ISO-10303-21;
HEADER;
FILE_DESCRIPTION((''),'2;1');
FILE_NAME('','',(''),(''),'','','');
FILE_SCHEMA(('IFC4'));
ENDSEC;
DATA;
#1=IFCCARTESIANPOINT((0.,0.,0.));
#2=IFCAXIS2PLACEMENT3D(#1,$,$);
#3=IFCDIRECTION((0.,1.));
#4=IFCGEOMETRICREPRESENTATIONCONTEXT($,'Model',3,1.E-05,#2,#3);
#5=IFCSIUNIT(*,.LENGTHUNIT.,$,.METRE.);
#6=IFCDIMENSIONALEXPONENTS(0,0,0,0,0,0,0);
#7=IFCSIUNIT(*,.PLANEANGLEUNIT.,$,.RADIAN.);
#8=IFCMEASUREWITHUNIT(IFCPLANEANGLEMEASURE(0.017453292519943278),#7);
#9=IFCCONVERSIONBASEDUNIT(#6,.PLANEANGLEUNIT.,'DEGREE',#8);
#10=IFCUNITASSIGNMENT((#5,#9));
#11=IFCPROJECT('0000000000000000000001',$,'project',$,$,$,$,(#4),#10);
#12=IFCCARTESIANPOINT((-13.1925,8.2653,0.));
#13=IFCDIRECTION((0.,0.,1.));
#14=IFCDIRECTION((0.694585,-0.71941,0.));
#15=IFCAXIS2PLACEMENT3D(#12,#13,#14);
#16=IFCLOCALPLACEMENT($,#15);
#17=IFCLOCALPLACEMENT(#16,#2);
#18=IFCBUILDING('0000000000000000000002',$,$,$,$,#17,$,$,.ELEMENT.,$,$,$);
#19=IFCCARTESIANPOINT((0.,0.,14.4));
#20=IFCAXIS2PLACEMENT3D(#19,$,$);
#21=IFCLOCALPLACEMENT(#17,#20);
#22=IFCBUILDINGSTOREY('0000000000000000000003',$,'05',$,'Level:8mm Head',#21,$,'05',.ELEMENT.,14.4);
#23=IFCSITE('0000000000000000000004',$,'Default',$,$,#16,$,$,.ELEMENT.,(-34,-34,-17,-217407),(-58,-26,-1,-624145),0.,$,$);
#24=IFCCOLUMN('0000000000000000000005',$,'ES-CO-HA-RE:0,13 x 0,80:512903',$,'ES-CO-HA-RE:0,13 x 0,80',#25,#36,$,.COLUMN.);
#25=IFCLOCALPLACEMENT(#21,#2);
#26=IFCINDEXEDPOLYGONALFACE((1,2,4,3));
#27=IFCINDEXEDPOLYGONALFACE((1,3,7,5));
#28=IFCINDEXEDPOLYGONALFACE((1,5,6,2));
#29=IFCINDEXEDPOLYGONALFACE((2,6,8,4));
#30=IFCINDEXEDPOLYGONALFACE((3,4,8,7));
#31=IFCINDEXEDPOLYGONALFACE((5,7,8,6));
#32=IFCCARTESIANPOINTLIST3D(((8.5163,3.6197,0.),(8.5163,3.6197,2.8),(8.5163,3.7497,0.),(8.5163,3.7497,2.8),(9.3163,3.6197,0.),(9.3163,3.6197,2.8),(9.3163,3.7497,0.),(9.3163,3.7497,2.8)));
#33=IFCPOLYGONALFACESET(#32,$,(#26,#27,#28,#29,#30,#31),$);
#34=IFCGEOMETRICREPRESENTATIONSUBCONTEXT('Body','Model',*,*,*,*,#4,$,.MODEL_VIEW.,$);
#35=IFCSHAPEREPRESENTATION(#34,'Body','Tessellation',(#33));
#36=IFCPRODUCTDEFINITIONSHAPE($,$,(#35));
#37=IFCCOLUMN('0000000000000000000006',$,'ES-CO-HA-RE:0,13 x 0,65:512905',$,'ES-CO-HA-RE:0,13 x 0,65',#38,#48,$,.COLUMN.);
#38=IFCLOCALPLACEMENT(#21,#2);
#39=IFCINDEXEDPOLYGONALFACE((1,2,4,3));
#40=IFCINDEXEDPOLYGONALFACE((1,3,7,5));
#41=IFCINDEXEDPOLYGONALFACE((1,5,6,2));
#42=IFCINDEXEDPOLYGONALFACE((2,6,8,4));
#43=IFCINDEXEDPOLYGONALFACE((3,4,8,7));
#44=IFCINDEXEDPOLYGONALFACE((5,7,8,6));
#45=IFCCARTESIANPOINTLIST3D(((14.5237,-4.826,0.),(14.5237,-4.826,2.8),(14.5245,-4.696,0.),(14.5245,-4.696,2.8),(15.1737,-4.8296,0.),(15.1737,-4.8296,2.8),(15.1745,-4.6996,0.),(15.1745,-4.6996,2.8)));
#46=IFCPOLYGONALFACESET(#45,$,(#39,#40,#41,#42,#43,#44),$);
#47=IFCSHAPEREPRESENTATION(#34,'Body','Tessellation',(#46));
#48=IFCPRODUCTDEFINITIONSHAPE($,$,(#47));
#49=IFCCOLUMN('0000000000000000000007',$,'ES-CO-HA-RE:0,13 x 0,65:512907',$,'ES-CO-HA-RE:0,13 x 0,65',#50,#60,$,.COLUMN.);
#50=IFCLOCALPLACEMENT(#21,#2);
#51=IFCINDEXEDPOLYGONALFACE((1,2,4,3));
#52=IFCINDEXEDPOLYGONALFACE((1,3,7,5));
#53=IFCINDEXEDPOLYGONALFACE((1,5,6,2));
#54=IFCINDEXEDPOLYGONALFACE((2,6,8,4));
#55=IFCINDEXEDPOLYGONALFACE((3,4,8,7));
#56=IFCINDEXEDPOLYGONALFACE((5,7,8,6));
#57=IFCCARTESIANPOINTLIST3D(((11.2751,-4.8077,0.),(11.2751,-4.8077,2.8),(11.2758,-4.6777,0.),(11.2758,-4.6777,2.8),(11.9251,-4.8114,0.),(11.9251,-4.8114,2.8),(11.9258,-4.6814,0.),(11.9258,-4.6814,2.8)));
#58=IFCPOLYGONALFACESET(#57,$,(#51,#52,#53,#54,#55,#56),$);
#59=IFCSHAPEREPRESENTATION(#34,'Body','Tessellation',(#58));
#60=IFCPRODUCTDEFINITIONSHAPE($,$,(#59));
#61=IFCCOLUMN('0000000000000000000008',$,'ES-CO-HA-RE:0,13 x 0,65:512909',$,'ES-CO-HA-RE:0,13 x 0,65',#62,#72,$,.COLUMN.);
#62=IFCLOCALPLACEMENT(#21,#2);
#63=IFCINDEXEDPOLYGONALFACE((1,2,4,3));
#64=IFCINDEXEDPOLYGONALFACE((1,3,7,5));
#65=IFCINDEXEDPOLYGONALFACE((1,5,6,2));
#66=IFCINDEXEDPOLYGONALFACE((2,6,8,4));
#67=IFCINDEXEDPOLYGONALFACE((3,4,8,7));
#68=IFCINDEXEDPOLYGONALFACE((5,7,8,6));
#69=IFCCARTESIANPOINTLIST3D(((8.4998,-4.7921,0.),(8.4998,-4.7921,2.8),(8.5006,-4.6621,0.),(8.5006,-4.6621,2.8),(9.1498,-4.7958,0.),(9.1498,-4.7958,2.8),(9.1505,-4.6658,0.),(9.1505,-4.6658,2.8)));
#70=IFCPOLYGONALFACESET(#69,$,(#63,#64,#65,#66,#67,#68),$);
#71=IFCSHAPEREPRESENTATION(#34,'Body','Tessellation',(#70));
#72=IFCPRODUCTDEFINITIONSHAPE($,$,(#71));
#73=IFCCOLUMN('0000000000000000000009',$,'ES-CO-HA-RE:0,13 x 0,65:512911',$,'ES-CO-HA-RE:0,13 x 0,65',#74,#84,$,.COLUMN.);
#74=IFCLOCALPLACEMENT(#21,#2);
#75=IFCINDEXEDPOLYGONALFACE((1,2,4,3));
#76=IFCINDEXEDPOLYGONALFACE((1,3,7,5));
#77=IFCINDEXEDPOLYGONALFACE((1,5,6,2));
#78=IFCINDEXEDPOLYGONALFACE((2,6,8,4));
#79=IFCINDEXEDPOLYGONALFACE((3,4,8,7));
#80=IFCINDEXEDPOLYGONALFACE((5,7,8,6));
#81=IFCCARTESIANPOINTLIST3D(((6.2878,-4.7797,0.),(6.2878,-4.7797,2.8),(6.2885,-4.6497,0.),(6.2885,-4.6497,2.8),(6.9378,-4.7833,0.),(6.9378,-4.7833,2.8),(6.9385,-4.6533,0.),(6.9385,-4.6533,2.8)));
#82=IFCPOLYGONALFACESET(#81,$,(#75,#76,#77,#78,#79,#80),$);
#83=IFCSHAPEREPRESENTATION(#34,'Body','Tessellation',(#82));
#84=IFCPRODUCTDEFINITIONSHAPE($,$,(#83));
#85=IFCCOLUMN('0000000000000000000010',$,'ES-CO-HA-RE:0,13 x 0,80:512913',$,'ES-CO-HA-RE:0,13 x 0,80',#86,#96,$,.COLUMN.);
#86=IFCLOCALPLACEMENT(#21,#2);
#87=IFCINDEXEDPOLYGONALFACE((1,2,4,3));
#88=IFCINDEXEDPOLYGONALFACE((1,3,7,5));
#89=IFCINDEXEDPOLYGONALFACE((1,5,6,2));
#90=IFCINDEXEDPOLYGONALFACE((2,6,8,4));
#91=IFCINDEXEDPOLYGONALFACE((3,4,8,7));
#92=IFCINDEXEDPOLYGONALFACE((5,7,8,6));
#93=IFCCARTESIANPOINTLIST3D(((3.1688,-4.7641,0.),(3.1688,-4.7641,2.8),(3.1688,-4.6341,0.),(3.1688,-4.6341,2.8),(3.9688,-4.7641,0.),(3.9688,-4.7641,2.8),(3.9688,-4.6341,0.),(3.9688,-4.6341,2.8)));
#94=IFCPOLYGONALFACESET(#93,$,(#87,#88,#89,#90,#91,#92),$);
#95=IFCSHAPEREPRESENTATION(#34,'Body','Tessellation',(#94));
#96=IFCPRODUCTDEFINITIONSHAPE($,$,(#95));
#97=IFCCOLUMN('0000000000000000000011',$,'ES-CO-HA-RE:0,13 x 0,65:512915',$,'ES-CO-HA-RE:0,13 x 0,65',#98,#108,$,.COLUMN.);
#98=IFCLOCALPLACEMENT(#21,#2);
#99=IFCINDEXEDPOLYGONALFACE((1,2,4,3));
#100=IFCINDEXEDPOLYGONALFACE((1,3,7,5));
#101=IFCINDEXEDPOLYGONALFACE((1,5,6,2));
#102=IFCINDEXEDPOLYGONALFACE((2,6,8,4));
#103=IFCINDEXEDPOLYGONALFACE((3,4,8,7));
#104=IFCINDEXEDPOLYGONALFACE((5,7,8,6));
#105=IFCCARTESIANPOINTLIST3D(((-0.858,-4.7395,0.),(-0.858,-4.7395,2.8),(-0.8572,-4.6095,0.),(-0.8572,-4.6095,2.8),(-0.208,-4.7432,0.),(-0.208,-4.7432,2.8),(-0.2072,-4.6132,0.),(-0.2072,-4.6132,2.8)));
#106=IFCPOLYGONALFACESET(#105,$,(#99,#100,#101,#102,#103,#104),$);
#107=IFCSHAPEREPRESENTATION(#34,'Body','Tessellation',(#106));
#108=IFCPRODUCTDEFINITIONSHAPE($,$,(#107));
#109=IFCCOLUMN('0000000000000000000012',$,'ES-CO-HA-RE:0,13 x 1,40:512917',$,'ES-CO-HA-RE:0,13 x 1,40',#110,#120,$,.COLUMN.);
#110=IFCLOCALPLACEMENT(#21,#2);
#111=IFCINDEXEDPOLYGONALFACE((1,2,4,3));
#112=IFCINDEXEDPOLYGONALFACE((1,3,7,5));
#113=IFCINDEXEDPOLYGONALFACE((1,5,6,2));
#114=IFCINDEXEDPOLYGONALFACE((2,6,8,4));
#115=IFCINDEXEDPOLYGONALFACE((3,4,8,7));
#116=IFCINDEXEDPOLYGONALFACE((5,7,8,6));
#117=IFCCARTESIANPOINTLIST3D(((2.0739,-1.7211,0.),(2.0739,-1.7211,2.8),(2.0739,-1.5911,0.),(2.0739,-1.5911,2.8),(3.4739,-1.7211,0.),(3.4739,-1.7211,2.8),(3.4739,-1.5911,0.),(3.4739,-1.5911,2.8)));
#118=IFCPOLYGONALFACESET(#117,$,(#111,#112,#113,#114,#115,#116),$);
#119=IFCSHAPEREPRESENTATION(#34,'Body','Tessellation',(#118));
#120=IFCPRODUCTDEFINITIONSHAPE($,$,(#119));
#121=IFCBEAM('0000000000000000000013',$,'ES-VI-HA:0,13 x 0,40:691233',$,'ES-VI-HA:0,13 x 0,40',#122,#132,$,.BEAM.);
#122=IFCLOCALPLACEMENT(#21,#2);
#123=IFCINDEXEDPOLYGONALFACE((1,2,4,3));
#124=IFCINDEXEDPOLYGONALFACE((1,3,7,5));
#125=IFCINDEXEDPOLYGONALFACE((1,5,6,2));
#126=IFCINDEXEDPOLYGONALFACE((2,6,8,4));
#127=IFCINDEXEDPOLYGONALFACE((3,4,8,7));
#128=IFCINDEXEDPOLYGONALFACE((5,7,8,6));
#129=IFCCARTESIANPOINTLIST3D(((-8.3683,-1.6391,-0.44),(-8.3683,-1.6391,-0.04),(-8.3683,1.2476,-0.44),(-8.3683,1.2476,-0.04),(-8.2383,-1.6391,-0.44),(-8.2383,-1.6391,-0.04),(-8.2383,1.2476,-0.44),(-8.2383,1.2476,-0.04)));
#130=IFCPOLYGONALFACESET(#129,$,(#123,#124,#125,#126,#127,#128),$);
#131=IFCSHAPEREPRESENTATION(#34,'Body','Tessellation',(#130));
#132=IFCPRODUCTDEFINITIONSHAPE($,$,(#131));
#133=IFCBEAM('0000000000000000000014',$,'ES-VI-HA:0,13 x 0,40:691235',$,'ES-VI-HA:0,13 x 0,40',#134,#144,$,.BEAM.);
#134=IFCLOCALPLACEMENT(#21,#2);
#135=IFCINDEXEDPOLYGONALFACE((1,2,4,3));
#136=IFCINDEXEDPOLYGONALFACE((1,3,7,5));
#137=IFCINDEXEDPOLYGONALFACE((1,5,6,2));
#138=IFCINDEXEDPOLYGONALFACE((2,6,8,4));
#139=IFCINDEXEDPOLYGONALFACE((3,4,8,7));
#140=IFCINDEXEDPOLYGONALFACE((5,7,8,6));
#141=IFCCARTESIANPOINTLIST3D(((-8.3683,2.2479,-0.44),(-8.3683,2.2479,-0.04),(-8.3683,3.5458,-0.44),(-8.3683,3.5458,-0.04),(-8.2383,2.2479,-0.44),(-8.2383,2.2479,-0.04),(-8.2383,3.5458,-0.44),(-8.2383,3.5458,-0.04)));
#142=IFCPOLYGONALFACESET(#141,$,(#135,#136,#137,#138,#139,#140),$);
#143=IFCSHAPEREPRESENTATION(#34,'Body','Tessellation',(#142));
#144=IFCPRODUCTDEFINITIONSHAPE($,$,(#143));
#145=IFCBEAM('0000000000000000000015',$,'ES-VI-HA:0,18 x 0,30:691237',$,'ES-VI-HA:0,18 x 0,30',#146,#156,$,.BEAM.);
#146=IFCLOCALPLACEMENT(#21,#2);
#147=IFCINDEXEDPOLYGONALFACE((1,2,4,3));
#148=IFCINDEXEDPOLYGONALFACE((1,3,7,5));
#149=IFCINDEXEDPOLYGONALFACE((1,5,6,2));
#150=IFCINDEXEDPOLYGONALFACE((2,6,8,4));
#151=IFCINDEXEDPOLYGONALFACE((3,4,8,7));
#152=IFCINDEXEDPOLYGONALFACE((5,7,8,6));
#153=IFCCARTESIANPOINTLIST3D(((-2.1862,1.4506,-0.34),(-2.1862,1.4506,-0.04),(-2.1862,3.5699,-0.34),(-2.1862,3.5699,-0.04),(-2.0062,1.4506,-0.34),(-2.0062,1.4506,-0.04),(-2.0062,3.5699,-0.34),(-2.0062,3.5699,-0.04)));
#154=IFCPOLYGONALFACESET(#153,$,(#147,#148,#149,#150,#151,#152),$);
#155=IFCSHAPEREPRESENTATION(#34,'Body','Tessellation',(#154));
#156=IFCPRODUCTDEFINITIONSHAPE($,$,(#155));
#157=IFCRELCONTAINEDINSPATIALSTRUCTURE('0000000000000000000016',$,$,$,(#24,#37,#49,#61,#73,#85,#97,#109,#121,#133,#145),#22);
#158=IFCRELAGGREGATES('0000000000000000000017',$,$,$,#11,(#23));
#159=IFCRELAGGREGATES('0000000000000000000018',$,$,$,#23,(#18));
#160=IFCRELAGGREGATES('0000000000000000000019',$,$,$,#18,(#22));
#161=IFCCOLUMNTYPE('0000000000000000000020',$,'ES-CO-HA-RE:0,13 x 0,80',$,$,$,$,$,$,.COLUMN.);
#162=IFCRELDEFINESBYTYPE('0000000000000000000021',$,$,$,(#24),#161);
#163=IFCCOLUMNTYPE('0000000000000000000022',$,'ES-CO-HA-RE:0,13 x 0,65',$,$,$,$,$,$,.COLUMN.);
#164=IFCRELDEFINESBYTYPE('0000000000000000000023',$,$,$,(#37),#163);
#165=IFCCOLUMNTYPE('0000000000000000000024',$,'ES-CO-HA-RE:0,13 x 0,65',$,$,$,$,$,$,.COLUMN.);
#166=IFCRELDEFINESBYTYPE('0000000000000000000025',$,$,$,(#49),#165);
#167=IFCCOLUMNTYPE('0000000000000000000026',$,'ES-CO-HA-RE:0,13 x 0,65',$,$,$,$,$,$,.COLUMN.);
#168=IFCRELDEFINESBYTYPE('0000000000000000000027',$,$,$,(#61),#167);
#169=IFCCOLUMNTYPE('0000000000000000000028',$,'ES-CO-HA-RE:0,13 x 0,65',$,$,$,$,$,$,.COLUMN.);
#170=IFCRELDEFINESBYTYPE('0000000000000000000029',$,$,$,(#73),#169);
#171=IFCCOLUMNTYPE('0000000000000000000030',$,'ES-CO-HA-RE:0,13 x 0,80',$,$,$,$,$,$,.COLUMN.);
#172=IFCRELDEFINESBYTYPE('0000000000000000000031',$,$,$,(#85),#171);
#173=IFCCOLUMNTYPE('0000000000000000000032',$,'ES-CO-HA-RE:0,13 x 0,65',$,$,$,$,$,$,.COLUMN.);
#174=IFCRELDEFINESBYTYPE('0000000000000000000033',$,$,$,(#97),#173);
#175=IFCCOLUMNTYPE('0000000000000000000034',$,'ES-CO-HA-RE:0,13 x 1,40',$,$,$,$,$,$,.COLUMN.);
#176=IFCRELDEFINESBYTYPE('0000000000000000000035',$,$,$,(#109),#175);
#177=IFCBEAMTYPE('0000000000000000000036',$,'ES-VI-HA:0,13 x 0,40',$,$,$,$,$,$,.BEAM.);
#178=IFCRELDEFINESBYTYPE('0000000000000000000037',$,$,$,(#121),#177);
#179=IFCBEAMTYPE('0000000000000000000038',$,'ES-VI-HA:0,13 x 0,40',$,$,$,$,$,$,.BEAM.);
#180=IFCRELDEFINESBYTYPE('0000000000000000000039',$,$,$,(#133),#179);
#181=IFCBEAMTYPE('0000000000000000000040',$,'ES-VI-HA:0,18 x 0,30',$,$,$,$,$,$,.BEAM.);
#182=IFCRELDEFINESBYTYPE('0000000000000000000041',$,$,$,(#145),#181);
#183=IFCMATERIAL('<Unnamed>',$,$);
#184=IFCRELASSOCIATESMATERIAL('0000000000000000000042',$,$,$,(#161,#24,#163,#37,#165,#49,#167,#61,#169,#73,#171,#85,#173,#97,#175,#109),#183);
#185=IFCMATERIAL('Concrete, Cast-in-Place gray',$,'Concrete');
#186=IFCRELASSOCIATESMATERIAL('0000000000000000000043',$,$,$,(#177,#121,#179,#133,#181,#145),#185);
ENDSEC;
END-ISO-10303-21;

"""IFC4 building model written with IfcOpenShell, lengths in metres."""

from ifc_helpers import new_model, entity, si_unit, converted_unit, direction, frame, origin, place, context, subcontext, project, spatial, indexed_curve, outline, extrude, source, transform, mapped, material, type_object, type_shapes, element, save


model = new_model("IFC4")

# Units and contexts
model_context = context("Model", 3, precision=1e-05, world=origin(), true_north=direction((0.0, 1.0)))
body_context = subcontext(model_context, "Body", "Model", "MODEL_VIEW")
ifc_project = project(units=[si_unit("LENGTHUNIT", "METRE"), converted_unit("PLANEANGLEUNIT", "DEGREE", entity("IfcPlaneAngleMeasure", 0.017453292519943278), si_unit("PLANEANGLEUNIT", "RADIAN"), dimensions=[0, 0, 0, 0, 0, 0, 0])], contexts=[model_context])

# Site, building, storey
site_placement = place(None, frame((-13.1925, 8.2653, 0.0), z_axis=(0.0, 0.0, 1.0), x_axis=(0.694585, -0.71941, 0.0)))
site = spatial("IfcSite", under=ifc_project, at=site_placement, Name="Default", CompositionType="ELEMENT", RefLatitude=(-34, -34, -17, -217407), RefLongitude=(-58, -26, -1, -624145), RefElevation=0.0)
building_placement = place(site_placement, origin())
building = spatial("IfcBuilding", under=site, at=building_placement, CompositionType="ELEMENT")
storey_placement = place(building_placement, frame((0.0, 0.0, 14.4)))
storey = spatial("IfcBuildingStorey", under=building, at=storey_placement, Name="05", ObjectType="Level:8mm Head", LongName="05", CompositionType="ELEMENT", Elevation=14.4)

# Columns
ifc_material_1 = material(Name="<Unnamed>")
column_type_1 = type_object("IfcColumnType", Name="ES-CO-HA-RE:0,13 x 0,80", PredefinedType="COLUMN", material=ifc_material_1)
shared_shape_1 = source(origin(), body_context, "Body", "SweptSolid", [
    extrude(outline(indexed_curve([(-0.4, -0.065), (0.4, -0.065), (0.4, 0.065), (-0.4, 0.065), (-0.4, -0.065)], self_intersect=False)), frame((8.9163, 3.6847, 14.4), z_axis=(0.0, 0.0, 1.0), x_axis=(-1.0, 0.0, 0.0)), (0.0, 0.0, 1.0), 2.8),
])
type_shapes(column_type_1, [shared_shape_1])
column_1_placement = place(storey_placement, frame((0.0, 0.0, -14.4)))
element("IfcColumn", 1, at=column_1_placement, inside=storey, type_object=column_type_1, material=ifc_material_1, Name="ES-CO-HA-RE:0,13 x 0,80:512903", ObjectType="ES-CO-HA-RE:0,13 x 0,80", PredefinedType="COLUMN", context=body_context, shape_type="MappedRepresentation", body=[
    mapped(shared_shape_1, transform((0.0, 0.0, 0.0), scale=1.0)),
])
column_type_2 = type_object("IfcColumnType", Name="ES-CO-HA-RE:0,13 x 0,65", PredefinedType="COLUMN", material=ifc_material_1)
shared_shape_2 = source(origin(), body_context, "Body", "SweptSolid", [
    extrude(outline(indexed_curve([(-0.325, -0.065), (0.325, -0.065), (0.325, 0.065), (-0.325, 0.065), (-0.325, -0.065)], self_intersect=False)), frame((14.8491, -4.7628, 14.4), z_axis=(0.0, 0.0, 1.0), x_axis=(-0.999984, 0.005619, 0.0)), (0.0, 0.0, 1.0), 2.8),
])
type_shapes(column_type_2, [shared_shape_2])
column_2_placement = place(storey_placement, frame((0.0, 0.0, -14.4)))
element("IfcColumn", 2, at=column_2_placement, inside=storey, type_object=column_type_2, material=ifc_material_1, Name="ES-CO-HA-RE:0,13 x 0,65:512905", ObjectType="ES-CO-HA-RE:0,13 x 0,65", PredefinedType="COLUMN", context=body_context, shape_type="MappedRepresentation", body=[
    mapped(shared_shape_2, transform((0.0, 0.0, 0.0), scale=1.0)),
])
column_type_3 = type_object("IfcColumnType", Name="ES-CO-HA-RE:0,13 x 0,65", PredefinedType="COLUMN", material=ifc_material_1)
shared_shape_3 = source(origin(), body_context, "Body", "SweptSolid", [
    extrude(outline(indexed_curve([(-0.325, -0.065), (0.325, -0.065), (0.325, 0.065), (-0.325, 0.065), (-0.325, -0.065)], self_intersect=False)), frame((11.6005, -4.7445, 14.4), z_axis=(0.0, 0.0, 1.0), x_axis=(-0.999984, 0.005619, 0.0)), (0.0, 0.0, 1.0), 2.8),
])
type_shapes(column_type_3, [shared_shape_3])
column_3_placement = place(storey_placement, frame((0.0, 0.0, -14.4)))
element("IfcColumn", 3, at=column_3_placement, inside=storey, type_object=column_type_3, material=ifc_material_1, Name="ES-CO-HA-RE:0,13 x 0,65:512907", ObjectType="ES-CO-HA-RE:0,13 x 0,65", PredefinedType="COLUMN", context=body_context, shape_type="MappedRepresentation", body=[
    mapped(shared_shape_3, transform((0.0, 0.0, 0.0), scale=1.0)),
])
column_type_4 = type_object("IfcColumnType", Name="ES-CO-HA-RE:0,13 x 0,65", PredefinedType="COLUMN", material=ifc_material_1)
shared_shape_4 = source(origin(), body_context, "Body", "SweptSolid", [
    extrude(outline(indexed_curve([(-0.325, -0.065), (0.325, -0.065), (0.325, 0.065), (-0.325, 0.065), (-0.325, -0.065)], self_intersect=False)), frame((8.8252, -4.7289, 14.4), z_axis=(0.0, 0.0, 1.0), x_axis=(-0.999984, 0.005619, 0.0)), (0.0, 0.0, 1.0), 2.8),
])
type_shapes(column_type_4, [shared_shape_4])
column_4_placement = place(storey_placement, frame((0.0, 0.0, -14.4)))
element("IfcColumn", 4, at=column_4_placement, inside=storey, type_object=column_type_4, material=ifc_material_1, Name="ES-CO-HA-RE:0,13 x 0,65:512909", ObjectType="ES-CO-HA-RE:0,13 x 0,65", PredefinedType="COLUMN", context=body_context, shape_type="MappedRepresentation", body=[
    mapped(shared_shape_4, transform((0.0, 0.0, 0.0), scale=1.0)),
])
column_type_5 = type_object("IfcColumnType", Name="ES-CO-HA-RE:0,13 x 0,65", PredefinedType="COLUMN", material=ifc_material_1)
shared_shape_5 = source(origin(), body_context, "Body", "SweptSolid", [
    extrude(outline(indexed_curve([(-0.325, -0.065), (0.325, -0.065), (0.325, 0.065), (-0.325, 0.065), (-0.325, -0.065)], self_intersect=False)), frame((6.6131, -4.7165, 14.4), z_axis=(0.0, 0.0, 1.0), x_axis=(-0.999984, 0.005619, 0.0)), (0.0, 0.0, 1.0), 2.8),
])
type_shapes(column_type_5, [shared_shape_5])
column_5_placement = place(storey_placement, frame((0.0, 0.0, -14.4)))
element("IfcColumn", 5, at=column_5_placement, inside=storey, type_object=column_type_5, material=ifc_material_1, Name="ES-CO-HA-RE:0,13 x 0,65:512911", ObjectType="ES-CO-HA-RE:0,13 x 0,65", PredefinedType="COLUMN", context=body_context, shape_type="MappedRepresentation", body=[
    mapped(shared_shape_5, transform((0.0, 0.0, 0.0), scale=1.0)),
])
column_type_6 = type_object("IfcColumnType", Name="ES-CO-HA-RE:0,13 x 0,80", PredefinedType="COLUMN", material=ifc_material_1)
shared_shape_6 = source(origin(), body_context, "Body", "SweptSolid", [
    extrude(outline(indexed_curve([(-0.4, -0.065), (0.4, -0.065), (0.4, 0.065), (-0.4, 0.065), (-0.4, -0.065)], self_intersect=False)), frame((3.5688, -4.6991, 14.4), z_axis=(0.0, 0.0, 1.0), x_axis=(-1.0, 0.0, 0.0)), (0.0, 0.0, 1.0), 2.8),
])
type_shapes(column_type_6, [shared_shape_6])
column_6_placement = place(storey_placement, frame((0.0, 0.0, -14.4)))
element("IfcColumn", 6, at=column_6_placement, inside=storey, type_object=column_type_6, material=ifc_material_1, Name="ES-CO-HA-RE:0,13 x 0,80:512913", ObjectType="ES-CO-HA-RE:0,13 x 0,80", PredefinedType="COLUMN", context=body_context, shape_type="MappedRepresentation", body=[
    mapped(shared_shape_6, transform((0.0, 0.0, 0.0), scale=1.0)),
])
column_type_7 = type_object("IfcColumnType", Name="ES-CO-HA-RE:0,13 x 0,65", PredefinedType="COLUMN", material=ifc_material_1)
shared_shape_7 = source(origin(), body_context, "Body", "SweptSolid", [
    extrude(outline(indexed_curve([(-0.325, -0.065), (0.325, -0.065), (0.325, 0.065), (-0.325, 0.065), (-0.325, -0.065)], self_intersect=False)), frame((-0.5326, -4.6764, 14.4), z_axis=(0.0, 0.0, 1.0), x_axis=(-0.999984, 0.005619, 0.0)), (0.0, 0.0, 1.0), 2.8),
])
type_shapes(column_type_7, [shared_shape_7])
column_7_placement = place(storey_placement, frame((0.0, 0.0, -14.4)))
element("IfcColumn", 7, at=column_7_placement, inside=storey, type_object=column_type_7, material=ifc_material_1, Name="ES-CO-HA-RE:0,13 x 0,65:512915", ObjectType="ES-CO-HA-RE:0,13 x 0,65", PredefinedType="COLUMN", context=body_context, shape_type="MappedRepresentation", body=[
    mapped(shared_shape_7, transform((0.0, 0.0, 0.0), scale=1.0)),
])
column_type_8 = type_object("IfcColumnType", Name="ES-CO-HA-RE:0,13 x 1,40", PredefinedType="COLUMN", material=ifc_material_1)
shared_shape_8 = source(origin(), body_context, "Body", "SweptSolid", [
    extrude(outline(indexed_curve([(-0.7, -0.065), (0.7, -0.065), (0.7, 0.065), (-0.7, 0.065), (-0.7, -0.065)], self_intersect=False)), frame((2.7739, -1.6561, 14.4), z_axis=(0.0, 0.0, 1.0), x_axis=(-1.0, 0.0, 0.0)), (0.0, 0.0, 1.0), 2.8),
])
type_shapes(column_type_8, [shared_shape_8])
column_8_placement = place(storey_placement, frame((0.0, 0.0, -14.4)))
element("IfcColumn", 8, at=column_8_placement, inside=storey, type_object=column_type_8, material=ifc_material_1, Name="ES-CO-HA-RE:0,13 x 1,40:512917", ObjectType="ES-CO-HA-RE:0,13 x 1,40", PredefinedType="COLUMN", context=body_context, shape_type="MappedRepresentation", body=[
    mapped(shared_shape_8, transform((0.0, 0.0, 0.0), scale=1.0)),
])

# Beams
ifc_material_2 = material(Name="Concrete, Cast-in-Place gray", Category="Concrete")
beam_type_1 = type_object("IfcBeamType", Name="ES-VI-HA:0,13 x 0,40", PredefinedType="BEAM", material=ifc_material_2)
shared_shape_9 = source(origin(), body_context, "Body", "SweptSolid", [
    extrude(outline(indexed_curve([(-0.065, -0.2), (0.065, -0.2), (0.065, 0.2), (-0.065, 0.2), (-0.065, -0.2)], self_intersect=False)), frame((-8.3033, -1.6391, 14.16), z_axis=(0.0, 1.0, 0.0), x_axis=(-1.0, 0.0, 0.0)), (0.0, 0.0, 1.0), 2.8867),
])
type_shapes(beam_type_1, [shared_shape_9])
beam_1_placement = place(storey_placement, frame((0.0, 0.0, -14.4)))
element("IfcBeam", 9, at=beam_1_placement, inside=storey, type_object=beam_type_1, material=ifc_material_2, Name="ES-VI-HA:0,13 x 0,40:691233", ObjectType="ES-VI-HA:0,13 x 0,40", PredefinedType="BEAM", context=body_context, shape_type="MappedRepresentation", body=[
    mapped(shared_shape_9, transform((0.0, 0.0, 0.0), scale=1.0)),
])
beam_type_2 = type_object("IfcBeamType", Name="ES-VI-HA:0,13 x 0,40", PredefinedType="BEAM", material=ifc_material_2)
shared_shape_10 = source(origin(), body_context, "Body", "SweptSolid", [
    extrude(outline(indexed_curve([(-0.065, -0.2), (0.065, -0.2), (0.065, 0.2), (-0.065, 0.2), (-0.065, -0.2)], self_intersect=False)), frame((-8.3033, 2.2479, 14.16), z_axis=(0.0, 1.0, 0.0), x_axis=(-1.0, 0.0, 0.0)), (0.0, 0.0, 1.0), 1.298),
])
type_shapes(beam_type_2, [shared_shape_10])
beam_2_placement = place(storey_placement, frame((0.0, 0.0, -14.4)))
element("IfcBeam", 10, at=beam_2_placement, inside=storey, type_object=beam_type_2, material=ifc_material_2, Name="ES-VI-HA:0,13 x 0,40:691235", ObjectType="ES-VI-HA:0,13 x 0,40", PredefinedType="BEAM", context=body_context, shape_type="MappedRepresentation", body=[
    mapped(shared_shape_10, transform((0.0, 0.0, 0.0), scale=1.0)),
])
beam_type_3 = type_object("IfcBeamType", Name="ES-VI-HA:0,18 x 0,30", PredefinedType="BEAM", material=ifc_material_2)
shared_shape_11 = source(origin(), body_context, "Body", "SweptSolid", [
    extrude(outline(indexed_curve([(-0.09, -0.15), (0.09, -0.15), (0.09, 0.15), (-0.09, 0.15), (-0.09, -0.15)], self_intersect=False)), frame((-2.0962, 3.5699, 14.21), z_axis=(0.0, -1.0, 0.0), x_axis=(-1.0, 0.0, 0.0)), (0.0, 0.0, 1.0), 2.1193),
])
type_shapes(beam_type_3, [shared_shape_11])
beam_3_placement = place(storey_placement, frame((0.0, 0.0, -14.4)))
element("IfcBeam", 11, at=beam_3_placement, inside=storey, type_object=beam_type_3, material=ifc_material_2, Name="ES-VI-HA:0,18 x 0,30:691237", ObjectType="ES-VI-HA:0,18 x 0,30", PredefinedType="BEAM", context=body_context, shape_type="MappedRepresentation", body=[
    mapped(shared_shape_11, transform((0.0, 0.0, 0.0), scale=1.0)),
])

save(model, "model.ifc")
